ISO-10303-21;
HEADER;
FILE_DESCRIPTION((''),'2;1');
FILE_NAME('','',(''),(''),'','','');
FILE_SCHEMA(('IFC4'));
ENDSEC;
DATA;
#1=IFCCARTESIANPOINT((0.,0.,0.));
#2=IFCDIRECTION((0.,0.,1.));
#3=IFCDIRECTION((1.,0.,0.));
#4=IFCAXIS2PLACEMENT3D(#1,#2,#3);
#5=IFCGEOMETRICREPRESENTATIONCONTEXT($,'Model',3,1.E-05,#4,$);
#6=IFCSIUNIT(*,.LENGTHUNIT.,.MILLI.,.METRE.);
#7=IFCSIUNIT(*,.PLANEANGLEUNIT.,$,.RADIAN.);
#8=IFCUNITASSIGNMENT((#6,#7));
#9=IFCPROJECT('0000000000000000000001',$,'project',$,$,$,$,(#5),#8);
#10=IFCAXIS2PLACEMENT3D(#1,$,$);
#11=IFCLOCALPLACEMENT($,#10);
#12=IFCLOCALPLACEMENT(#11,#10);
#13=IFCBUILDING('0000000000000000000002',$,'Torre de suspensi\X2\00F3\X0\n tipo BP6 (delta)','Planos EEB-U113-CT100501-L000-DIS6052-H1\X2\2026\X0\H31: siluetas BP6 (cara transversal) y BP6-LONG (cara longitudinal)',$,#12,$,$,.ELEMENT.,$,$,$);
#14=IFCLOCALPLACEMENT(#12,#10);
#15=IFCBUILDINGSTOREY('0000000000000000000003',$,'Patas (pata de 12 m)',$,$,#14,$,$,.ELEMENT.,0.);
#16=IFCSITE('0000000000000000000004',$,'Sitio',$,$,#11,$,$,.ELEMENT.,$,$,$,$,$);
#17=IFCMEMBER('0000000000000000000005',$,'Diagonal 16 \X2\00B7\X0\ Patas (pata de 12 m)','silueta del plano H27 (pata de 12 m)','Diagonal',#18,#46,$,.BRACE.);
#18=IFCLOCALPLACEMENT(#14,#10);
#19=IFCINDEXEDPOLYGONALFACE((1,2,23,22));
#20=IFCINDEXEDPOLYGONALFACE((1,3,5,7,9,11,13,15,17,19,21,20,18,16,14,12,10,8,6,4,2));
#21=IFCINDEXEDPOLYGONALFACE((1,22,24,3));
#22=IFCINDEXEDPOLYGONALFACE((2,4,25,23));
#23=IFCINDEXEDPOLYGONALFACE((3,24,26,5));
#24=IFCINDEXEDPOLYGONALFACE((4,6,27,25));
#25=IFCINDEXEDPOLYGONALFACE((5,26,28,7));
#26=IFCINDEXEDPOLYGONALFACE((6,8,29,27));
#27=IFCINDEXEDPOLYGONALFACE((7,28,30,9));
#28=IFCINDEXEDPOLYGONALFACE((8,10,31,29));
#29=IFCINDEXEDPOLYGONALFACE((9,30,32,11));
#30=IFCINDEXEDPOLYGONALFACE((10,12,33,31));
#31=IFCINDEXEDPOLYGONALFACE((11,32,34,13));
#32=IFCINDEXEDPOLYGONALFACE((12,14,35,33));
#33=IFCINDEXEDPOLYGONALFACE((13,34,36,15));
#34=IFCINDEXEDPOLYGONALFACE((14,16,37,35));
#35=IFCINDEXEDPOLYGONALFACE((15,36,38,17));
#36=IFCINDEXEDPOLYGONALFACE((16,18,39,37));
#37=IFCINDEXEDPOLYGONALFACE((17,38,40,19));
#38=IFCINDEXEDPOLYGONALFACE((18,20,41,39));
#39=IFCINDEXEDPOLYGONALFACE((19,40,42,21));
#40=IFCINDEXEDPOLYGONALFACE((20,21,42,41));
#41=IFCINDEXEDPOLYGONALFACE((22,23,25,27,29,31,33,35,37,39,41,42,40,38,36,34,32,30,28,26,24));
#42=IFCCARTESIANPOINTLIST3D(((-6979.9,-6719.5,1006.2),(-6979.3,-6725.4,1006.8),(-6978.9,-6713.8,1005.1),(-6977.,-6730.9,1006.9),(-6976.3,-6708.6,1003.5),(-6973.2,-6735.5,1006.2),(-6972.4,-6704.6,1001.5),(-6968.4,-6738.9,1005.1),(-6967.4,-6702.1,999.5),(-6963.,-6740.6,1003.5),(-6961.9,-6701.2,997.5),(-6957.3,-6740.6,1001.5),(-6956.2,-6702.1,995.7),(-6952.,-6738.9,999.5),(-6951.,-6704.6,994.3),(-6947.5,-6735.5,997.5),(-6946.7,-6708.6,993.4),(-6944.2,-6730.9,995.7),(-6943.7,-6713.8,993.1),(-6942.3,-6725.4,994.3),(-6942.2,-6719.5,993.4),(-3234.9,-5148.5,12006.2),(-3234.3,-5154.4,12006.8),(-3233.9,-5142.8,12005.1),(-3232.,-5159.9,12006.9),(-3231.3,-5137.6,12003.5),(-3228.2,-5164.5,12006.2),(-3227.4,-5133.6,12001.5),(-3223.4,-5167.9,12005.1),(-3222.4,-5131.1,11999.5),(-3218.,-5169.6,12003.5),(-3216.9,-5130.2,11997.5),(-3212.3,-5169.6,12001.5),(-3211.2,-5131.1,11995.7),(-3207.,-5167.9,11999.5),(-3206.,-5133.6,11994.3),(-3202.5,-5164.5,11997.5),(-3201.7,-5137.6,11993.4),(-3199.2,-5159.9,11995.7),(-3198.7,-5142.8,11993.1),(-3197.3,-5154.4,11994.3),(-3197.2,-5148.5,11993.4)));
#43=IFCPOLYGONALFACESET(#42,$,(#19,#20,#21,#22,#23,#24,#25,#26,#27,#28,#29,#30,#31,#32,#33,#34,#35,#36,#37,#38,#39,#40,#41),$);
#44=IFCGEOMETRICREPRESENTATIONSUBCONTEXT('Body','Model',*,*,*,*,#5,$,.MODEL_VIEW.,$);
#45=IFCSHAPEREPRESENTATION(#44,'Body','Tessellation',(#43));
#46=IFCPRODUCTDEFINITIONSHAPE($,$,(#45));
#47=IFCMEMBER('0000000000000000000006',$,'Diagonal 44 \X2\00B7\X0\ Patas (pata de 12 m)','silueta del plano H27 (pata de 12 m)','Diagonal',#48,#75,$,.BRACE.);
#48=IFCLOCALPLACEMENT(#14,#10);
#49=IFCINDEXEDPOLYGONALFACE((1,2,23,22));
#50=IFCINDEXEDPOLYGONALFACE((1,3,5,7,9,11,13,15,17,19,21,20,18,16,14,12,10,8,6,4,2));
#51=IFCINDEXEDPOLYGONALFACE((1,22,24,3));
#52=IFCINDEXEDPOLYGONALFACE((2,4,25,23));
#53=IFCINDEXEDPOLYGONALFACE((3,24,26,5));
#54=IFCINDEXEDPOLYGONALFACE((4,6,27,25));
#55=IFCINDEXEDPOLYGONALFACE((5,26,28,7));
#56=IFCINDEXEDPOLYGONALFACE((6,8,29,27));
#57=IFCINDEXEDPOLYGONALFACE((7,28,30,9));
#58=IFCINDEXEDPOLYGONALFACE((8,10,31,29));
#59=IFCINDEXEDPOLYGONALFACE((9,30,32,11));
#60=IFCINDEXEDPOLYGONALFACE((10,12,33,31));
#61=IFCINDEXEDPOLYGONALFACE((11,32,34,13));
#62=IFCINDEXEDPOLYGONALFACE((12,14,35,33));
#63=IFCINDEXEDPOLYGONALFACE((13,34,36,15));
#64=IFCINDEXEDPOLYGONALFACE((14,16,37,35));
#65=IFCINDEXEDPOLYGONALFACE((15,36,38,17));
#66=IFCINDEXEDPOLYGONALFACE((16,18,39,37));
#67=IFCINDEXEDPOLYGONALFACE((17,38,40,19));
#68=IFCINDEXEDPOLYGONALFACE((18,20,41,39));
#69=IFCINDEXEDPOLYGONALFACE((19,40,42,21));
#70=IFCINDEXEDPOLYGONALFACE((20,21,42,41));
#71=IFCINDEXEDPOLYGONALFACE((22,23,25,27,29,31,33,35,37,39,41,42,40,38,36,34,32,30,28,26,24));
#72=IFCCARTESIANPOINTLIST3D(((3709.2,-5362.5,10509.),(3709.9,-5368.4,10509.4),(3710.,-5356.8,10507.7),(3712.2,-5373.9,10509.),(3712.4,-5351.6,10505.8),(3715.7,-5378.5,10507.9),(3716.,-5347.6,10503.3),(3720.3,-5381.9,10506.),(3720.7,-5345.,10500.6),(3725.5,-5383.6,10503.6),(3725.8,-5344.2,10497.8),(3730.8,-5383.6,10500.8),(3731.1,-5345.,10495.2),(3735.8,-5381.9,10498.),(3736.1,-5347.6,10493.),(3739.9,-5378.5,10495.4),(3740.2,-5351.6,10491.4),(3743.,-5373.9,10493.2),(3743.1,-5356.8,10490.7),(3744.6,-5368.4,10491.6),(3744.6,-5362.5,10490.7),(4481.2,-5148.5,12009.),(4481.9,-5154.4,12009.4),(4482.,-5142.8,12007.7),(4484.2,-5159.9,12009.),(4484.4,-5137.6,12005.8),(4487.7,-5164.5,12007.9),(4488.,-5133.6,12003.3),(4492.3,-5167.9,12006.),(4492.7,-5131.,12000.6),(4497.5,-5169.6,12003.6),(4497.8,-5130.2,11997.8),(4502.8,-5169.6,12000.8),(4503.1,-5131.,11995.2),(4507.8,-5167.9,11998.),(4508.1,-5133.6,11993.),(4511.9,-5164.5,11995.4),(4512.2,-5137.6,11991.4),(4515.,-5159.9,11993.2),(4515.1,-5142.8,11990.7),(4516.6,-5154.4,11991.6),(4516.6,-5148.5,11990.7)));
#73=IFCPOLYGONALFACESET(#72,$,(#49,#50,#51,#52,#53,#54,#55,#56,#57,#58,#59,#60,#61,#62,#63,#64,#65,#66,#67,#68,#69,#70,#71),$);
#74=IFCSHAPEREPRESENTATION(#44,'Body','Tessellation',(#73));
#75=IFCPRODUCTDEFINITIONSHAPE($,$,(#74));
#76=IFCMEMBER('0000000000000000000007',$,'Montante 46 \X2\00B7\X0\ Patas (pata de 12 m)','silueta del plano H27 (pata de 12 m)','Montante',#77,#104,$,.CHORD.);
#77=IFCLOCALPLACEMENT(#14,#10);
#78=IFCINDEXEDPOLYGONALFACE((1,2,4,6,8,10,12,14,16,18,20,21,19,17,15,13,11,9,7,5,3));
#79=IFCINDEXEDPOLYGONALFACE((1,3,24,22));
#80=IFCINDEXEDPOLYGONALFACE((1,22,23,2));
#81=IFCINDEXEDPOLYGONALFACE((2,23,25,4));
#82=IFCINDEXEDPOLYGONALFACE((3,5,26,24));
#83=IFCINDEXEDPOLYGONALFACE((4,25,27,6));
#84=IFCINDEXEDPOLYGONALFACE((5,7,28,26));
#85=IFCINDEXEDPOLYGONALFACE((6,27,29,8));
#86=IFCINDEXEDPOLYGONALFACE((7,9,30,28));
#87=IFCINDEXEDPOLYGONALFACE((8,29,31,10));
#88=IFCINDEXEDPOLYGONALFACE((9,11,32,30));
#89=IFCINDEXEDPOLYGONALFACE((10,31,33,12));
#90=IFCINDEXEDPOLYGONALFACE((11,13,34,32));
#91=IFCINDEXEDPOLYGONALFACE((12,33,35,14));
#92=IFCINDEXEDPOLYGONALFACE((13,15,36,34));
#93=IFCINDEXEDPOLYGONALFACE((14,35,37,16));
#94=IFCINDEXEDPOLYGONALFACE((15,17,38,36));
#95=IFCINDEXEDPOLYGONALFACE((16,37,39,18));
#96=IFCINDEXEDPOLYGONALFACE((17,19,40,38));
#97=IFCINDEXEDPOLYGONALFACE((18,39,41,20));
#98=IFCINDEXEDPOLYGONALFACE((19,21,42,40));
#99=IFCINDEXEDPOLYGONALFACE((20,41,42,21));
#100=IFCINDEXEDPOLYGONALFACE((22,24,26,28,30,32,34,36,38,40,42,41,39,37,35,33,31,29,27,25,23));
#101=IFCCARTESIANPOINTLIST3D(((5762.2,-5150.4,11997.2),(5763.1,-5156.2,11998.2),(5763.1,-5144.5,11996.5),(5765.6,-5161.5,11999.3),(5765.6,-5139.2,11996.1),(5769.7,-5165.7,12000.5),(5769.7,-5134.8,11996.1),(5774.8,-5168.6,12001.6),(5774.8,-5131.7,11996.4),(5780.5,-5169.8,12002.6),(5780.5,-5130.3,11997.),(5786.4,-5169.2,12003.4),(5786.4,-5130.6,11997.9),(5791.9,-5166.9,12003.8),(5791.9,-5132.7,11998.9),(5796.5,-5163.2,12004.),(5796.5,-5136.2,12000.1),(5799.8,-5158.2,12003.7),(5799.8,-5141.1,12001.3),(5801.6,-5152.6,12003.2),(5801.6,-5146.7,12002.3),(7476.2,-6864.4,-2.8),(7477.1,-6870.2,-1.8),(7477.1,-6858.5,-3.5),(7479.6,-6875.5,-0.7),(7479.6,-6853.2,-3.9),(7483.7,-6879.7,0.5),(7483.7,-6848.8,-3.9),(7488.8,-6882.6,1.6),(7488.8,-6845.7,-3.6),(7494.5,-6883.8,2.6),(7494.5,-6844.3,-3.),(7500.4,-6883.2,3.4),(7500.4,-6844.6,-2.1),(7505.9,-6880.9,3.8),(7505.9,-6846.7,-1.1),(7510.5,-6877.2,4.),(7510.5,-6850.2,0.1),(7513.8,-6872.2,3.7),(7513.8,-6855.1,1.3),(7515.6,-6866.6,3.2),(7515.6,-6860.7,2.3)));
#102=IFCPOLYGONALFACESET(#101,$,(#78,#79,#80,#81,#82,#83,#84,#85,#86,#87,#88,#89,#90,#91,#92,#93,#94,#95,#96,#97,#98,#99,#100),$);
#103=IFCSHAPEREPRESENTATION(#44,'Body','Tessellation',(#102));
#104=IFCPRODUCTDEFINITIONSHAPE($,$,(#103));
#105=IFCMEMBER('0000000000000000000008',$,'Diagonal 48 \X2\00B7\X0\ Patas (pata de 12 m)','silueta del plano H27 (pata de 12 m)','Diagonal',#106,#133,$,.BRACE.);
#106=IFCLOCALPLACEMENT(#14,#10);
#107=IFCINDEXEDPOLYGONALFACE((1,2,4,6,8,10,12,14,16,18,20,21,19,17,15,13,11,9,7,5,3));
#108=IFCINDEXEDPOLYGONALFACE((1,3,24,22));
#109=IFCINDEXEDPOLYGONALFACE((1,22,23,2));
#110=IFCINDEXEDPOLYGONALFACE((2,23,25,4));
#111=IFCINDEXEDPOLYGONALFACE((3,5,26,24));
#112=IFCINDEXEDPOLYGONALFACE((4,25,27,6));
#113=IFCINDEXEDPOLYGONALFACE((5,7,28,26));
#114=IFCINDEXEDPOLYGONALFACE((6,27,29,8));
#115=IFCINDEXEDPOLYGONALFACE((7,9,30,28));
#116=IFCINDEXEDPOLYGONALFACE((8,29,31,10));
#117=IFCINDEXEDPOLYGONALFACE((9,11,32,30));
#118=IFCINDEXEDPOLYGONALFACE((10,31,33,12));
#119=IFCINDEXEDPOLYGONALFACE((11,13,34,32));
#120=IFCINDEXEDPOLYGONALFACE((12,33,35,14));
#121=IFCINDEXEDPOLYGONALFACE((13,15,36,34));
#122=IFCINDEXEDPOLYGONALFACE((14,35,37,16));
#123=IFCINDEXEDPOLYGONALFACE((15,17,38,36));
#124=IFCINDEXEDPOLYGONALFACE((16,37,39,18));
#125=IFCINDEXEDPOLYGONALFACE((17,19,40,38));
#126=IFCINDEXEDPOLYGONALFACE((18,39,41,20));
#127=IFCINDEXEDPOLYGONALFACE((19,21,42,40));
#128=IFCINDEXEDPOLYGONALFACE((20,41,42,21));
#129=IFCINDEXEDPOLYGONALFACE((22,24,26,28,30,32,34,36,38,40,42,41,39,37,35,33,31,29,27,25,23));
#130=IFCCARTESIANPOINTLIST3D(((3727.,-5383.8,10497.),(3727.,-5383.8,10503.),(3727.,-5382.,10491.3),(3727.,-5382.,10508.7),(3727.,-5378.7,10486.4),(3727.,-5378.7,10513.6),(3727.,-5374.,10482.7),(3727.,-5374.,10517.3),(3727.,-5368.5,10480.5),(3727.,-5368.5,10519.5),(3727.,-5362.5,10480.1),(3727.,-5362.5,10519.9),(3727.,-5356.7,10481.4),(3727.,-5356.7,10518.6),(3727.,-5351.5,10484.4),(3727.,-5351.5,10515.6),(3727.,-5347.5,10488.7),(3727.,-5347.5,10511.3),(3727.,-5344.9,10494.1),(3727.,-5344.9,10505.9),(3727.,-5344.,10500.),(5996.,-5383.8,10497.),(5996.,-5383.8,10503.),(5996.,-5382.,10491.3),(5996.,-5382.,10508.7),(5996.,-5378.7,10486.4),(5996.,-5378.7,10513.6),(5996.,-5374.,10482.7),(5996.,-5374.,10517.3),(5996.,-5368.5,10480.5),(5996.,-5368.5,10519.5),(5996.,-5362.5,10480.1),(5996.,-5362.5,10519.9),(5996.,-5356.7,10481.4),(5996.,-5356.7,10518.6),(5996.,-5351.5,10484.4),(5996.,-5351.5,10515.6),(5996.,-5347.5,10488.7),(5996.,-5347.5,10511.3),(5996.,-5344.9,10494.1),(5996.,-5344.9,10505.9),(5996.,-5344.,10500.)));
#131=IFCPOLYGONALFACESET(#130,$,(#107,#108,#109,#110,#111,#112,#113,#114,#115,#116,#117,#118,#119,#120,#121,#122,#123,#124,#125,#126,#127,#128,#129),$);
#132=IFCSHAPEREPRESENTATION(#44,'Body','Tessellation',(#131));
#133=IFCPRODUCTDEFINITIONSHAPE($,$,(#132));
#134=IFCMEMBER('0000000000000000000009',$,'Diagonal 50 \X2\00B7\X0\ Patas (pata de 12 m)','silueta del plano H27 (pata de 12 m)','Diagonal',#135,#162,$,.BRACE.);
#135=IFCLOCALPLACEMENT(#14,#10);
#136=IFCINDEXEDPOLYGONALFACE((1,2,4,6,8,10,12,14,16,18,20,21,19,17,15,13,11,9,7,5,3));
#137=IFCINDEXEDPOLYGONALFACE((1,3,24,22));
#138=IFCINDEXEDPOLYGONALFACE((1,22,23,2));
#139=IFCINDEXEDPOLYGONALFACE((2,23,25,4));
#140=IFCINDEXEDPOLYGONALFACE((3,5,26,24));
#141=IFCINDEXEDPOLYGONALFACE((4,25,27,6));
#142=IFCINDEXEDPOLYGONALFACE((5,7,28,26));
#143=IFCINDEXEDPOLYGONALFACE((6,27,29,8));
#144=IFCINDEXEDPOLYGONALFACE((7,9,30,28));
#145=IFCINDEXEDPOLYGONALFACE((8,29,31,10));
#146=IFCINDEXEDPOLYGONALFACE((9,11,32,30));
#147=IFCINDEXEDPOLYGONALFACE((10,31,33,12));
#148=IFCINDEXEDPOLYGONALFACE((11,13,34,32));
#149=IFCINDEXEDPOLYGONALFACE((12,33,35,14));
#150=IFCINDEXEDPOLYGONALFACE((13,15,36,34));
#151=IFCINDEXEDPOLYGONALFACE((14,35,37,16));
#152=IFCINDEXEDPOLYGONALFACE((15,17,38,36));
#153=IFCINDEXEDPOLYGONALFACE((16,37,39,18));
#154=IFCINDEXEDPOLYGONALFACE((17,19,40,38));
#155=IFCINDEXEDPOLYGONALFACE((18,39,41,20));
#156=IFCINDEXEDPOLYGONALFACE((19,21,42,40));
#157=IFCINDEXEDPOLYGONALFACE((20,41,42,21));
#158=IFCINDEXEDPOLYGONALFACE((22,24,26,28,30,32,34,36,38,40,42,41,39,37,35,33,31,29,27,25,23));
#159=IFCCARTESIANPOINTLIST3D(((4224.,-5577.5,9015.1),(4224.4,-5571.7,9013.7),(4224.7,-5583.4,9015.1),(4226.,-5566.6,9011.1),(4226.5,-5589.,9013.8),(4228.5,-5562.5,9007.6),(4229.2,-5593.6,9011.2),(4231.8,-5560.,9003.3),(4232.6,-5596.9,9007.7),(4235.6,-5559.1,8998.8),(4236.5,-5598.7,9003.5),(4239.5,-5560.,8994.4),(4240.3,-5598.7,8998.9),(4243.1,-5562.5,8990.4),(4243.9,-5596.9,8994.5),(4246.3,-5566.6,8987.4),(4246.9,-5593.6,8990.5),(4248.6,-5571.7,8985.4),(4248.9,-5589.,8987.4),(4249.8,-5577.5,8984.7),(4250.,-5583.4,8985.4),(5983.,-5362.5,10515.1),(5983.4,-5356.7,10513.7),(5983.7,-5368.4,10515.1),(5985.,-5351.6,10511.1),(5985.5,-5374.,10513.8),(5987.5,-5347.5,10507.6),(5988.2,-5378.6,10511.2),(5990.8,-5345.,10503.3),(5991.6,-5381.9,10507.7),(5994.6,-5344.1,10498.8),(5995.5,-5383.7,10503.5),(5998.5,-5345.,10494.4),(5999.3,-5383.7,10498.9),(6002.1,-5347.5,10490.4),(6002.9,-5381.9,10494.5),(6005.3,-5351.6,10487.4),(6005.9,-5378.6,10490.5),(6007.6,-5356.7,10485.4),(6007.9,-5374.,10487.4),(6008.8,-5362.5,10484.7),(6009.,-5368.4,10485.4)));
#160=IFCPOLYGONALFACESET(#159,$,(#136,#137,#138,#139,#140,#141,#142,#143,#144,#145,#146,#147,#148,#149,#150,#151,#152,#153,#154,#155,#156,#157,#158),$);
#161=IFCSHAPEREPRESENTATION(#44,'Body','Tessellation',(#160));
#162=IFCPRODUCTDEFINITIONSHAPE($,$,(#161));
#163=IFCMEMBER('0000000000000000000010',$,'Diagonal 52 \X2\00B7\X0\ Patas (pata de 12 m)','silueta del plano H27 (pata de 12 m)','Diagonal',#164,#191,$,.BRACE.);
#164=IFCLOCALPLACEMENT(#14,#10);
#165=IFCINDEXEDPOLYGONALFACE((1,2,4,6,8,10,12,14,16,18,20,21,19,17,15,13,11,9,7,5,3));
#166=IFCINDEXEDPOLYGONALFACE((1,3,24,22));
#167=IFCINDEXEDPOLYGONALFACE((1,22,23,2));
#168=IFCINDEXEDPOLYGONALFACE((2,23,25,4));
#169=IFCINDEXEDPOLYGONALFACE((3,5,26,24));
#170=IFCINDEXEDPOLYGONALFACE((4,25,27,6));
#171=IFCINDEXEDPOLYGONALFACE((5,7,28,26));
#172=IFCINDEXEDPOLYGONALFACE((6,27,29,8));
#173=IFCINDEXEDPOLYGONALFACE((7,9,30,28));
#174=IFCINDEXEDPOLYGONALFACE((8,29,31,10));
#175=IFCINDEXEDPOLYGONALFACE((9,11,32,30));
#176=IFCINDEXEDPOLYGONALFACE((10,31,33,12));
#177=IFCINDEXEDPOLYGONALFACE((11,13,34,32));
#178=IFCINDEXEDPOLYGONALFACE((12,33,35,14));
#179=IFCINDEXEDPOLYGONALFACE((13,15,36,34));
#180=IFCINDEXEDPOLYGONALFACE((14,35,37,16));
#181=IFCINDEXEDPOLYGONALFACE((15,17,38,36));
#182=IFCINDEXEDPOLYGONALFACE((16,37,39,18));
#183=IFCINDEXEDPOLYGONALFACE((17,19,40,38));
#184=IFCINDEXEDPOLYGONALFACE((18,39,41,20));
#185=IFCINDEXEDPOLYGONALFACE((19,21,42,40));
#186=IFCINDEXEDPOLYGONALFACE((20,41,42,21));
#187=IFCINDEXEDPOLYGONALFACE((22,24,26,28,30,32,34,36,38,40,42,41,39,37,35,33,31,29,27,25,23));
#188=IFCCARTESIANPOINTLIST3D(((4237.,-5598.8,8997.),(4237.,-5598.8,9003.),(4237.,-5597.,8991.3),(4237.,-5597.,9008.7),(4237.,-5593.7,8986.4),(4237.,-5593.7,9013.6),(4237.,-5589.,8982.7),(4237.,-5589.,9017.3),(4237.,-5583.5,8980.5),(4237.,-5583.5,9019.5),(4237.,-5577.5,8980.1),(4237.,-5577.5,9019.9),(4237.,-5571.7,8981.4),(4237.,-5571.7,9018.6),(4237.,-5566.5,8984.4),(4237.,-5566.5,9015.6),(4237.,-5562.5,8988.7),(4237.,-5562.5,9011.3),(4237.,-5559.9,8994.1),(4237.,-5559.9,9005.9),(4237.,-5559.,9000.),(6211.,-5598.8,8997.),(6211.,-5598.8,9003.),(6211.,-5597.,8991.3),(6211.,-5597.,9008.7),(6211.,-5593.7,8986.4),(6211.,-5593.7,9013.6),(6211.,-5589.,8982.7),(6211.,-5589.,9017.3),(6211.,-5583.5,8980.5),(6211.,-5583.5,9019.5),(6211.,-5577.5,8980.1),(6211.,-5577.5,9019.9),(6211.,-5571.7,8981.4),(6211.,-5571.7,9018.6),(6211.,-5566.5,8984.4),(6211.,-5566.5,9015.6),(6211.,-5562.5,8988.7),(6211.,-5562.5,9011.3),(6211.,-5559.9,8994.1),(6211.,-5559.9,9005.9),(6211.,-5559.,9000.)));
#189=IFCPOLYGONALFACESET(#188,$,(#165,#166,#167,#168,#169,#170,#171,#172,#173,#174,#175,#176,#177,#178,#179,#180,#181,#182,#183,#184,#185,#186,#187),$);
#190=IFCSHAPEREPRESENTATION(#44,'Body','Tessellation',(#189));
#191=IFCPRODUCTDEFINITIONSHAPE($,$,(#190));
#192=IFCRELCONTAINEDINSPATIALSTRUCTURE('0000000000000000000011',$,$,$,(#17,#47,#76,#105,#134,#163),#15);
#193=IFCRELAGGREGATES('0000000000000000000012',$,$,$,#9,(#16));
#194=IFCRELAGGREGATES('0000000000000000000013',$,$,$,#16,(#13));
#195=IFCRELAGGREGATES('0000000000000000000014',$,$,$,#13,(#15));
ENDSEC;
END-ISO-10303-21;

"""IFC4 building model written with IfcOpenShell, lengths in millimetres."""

from ifc_helpers import new_model, si_unit, frame, origin, origin_with_axes, place, context, subcontext, project, spatial, circle, extrude, element, save


model = new_model("IFC4")

# Units and contexts
model_context = context("Model", 3, precision=1e-05, world=origin_with_axes())
body_context = subcontext(model_context, "Body", "Model", "MODEL_VIEW")
ifc_project = project(units=[si_unit("LENGTHUNIT", "METRE", prefix="MILLI"), si_unit("PLANEANGLEUNIT", "RADIAN")], contexts=[model_context])

# Site, building, storey
site_placement = place(None, origin())
site = spatial("IfcSite", under=ifc_project, at=site_placement, Name="Sitio", CompositionType="ELEMENT")
building_placement = place(site_placement, origin())
building = spatial("IfcBuilding", under=site, at=building_placement, Name="Torre de suspensión tipo BP6 (delta)", Description="Planos EEB-U113-CT100501-L000-DIS6052-H1…H31: siluetas BP6 (cara transversal) y BP6-LONG (cara longitudinal)", CompositionType="ELEMENT")
storey_placement = place(building_placement, origin())
storey = spatial("IfcBuildingStorey", under=building, at=storey_placement, Name="Patas (pata de 12 m)", CompositionType="ELEMENT", Elevation=0.0)

# Members
member_1_placement = place(storey_placement, frame((-3216.0, -5150.0, 12000.0), z_axis=(-0.319383, -0.133979, -0.938107), x_axis=(-0.04318, 0.990984, -0.12683)))
element("IfcMember", 1, at=member_1_placement, inside=storey, Name="Diagonal 16 · Patas (pata de 12 m)", Description="silueta del plano H27 (pata de 12 m)", ObjectType="Diagonal", PredefinedType="BRACE", context=body_context, shape_type="SweptSolid", body=[
    extrude(circle(Radius=20.0), None, (0.0, 0.0, 1.0), 11725.7),
])
member_2_placement = place(storey_placement, frame((4499.0, -5150.0, 12000.0), z_axis=(-0.453978, -0.125844, -0.882081), x_axis=(-0.057588, 0.99205, -0.111894)))
element("IfcMember", 2, at=member_2_placement, inside=storey, Name="Diagonal 44 · Patas (pata de 12 m)", Description="silueta del plano H27 (pata de 12 m)", ObjectType="Diagonal", PredefinedType="BRACE", context=body_context, shape_type="SweptSolid", body=[
    extrude(circle(Radius=20.0), None, (0.0, 0.0, 1.0), 1700.5),
])
member_3_placement = place(storey_placement, frame((5782.0, -5150.0, 12000.0), z_axis=(0.140006, -0.140006, -0.980202), x_axis=(-0.990151, -0.019797, -0.138599)))
element("IfcMember", 3, at=member_3_placement, inside=storey, Name="Montante 46 · Patas (pata de 12 m)", Description="silueta del plano H27 (pata de 12 m)", ObjectType="Montante", PredefinedType="CHORD", context=body_context, shape_type="SweptSolid", body=[
    extrude(circle(Radius=20.0), None, (0.0, 0.0, 1.0), 12242.4),
])
member_4_placement = place(storey_placement, frame((3727.0, -5364.0, 10500.0), z_axis=(1.0, 0.0, 0.0), x_axis=(0.0, 1.0, 0.0)))
element("IfcMember", 4, at=member_4_placement, inside=storey, Name="Diagonal 48 · Patas (pata de 12 m)", Description="silueta del plano H27 (pata de 12 m)", ObjectType="Diagonal", PredefinedType="BRACE", context=body_context, shape_type="SweptSolid", body=[
    extrude(circle(Radius=20.0), None, (0.0, 0.0, 1.0), 2269.0),
])
member_5_placement = place(storey_placement, frame((4237.0, -5579.0, 9000.0), z_axis=(0.757633, 0.092604, 0.646077), x_axis=(-0.070463, 0.995703, -0.060088)))
element("IfcMember", 5, at=member_5_placement, inside=storey, Name="Diagonal 50 · Patas (pata de 12 m)", Description="silueta del plano H27 (pata de 12 m)", ObjectType="Diagonal", PredefinedType="BRACE", context=body_context, shape_type="SweptSolid", body=[
    extrude(circle(Radius=20.0), None, (0.0, 0.0, 1.0), 2321.7),
])
member_6_placement = place(storey_placement, frame((6211.0, -5579.0, 9000.0), z_axis=(-1.0, 0.0, 0.0), x_axis=(0.0, 1.0, 0.0)))
element("IfcMember", 6, at=member_6_placement, inside=storey, Name="Diagonal 52 · Patas (pata de 12 m)", Description="silueta del plano H27 (pata de 12 m)", ObjectType="Diagonal", PredefinedType="BRACE", context=body_context, shape_type="SweptSolid", body=[
    extrude(circle(Radius=20.0), None, (0.0, 0.0, 1.0), 1974.0),
])

save(model, "model.ifc")
